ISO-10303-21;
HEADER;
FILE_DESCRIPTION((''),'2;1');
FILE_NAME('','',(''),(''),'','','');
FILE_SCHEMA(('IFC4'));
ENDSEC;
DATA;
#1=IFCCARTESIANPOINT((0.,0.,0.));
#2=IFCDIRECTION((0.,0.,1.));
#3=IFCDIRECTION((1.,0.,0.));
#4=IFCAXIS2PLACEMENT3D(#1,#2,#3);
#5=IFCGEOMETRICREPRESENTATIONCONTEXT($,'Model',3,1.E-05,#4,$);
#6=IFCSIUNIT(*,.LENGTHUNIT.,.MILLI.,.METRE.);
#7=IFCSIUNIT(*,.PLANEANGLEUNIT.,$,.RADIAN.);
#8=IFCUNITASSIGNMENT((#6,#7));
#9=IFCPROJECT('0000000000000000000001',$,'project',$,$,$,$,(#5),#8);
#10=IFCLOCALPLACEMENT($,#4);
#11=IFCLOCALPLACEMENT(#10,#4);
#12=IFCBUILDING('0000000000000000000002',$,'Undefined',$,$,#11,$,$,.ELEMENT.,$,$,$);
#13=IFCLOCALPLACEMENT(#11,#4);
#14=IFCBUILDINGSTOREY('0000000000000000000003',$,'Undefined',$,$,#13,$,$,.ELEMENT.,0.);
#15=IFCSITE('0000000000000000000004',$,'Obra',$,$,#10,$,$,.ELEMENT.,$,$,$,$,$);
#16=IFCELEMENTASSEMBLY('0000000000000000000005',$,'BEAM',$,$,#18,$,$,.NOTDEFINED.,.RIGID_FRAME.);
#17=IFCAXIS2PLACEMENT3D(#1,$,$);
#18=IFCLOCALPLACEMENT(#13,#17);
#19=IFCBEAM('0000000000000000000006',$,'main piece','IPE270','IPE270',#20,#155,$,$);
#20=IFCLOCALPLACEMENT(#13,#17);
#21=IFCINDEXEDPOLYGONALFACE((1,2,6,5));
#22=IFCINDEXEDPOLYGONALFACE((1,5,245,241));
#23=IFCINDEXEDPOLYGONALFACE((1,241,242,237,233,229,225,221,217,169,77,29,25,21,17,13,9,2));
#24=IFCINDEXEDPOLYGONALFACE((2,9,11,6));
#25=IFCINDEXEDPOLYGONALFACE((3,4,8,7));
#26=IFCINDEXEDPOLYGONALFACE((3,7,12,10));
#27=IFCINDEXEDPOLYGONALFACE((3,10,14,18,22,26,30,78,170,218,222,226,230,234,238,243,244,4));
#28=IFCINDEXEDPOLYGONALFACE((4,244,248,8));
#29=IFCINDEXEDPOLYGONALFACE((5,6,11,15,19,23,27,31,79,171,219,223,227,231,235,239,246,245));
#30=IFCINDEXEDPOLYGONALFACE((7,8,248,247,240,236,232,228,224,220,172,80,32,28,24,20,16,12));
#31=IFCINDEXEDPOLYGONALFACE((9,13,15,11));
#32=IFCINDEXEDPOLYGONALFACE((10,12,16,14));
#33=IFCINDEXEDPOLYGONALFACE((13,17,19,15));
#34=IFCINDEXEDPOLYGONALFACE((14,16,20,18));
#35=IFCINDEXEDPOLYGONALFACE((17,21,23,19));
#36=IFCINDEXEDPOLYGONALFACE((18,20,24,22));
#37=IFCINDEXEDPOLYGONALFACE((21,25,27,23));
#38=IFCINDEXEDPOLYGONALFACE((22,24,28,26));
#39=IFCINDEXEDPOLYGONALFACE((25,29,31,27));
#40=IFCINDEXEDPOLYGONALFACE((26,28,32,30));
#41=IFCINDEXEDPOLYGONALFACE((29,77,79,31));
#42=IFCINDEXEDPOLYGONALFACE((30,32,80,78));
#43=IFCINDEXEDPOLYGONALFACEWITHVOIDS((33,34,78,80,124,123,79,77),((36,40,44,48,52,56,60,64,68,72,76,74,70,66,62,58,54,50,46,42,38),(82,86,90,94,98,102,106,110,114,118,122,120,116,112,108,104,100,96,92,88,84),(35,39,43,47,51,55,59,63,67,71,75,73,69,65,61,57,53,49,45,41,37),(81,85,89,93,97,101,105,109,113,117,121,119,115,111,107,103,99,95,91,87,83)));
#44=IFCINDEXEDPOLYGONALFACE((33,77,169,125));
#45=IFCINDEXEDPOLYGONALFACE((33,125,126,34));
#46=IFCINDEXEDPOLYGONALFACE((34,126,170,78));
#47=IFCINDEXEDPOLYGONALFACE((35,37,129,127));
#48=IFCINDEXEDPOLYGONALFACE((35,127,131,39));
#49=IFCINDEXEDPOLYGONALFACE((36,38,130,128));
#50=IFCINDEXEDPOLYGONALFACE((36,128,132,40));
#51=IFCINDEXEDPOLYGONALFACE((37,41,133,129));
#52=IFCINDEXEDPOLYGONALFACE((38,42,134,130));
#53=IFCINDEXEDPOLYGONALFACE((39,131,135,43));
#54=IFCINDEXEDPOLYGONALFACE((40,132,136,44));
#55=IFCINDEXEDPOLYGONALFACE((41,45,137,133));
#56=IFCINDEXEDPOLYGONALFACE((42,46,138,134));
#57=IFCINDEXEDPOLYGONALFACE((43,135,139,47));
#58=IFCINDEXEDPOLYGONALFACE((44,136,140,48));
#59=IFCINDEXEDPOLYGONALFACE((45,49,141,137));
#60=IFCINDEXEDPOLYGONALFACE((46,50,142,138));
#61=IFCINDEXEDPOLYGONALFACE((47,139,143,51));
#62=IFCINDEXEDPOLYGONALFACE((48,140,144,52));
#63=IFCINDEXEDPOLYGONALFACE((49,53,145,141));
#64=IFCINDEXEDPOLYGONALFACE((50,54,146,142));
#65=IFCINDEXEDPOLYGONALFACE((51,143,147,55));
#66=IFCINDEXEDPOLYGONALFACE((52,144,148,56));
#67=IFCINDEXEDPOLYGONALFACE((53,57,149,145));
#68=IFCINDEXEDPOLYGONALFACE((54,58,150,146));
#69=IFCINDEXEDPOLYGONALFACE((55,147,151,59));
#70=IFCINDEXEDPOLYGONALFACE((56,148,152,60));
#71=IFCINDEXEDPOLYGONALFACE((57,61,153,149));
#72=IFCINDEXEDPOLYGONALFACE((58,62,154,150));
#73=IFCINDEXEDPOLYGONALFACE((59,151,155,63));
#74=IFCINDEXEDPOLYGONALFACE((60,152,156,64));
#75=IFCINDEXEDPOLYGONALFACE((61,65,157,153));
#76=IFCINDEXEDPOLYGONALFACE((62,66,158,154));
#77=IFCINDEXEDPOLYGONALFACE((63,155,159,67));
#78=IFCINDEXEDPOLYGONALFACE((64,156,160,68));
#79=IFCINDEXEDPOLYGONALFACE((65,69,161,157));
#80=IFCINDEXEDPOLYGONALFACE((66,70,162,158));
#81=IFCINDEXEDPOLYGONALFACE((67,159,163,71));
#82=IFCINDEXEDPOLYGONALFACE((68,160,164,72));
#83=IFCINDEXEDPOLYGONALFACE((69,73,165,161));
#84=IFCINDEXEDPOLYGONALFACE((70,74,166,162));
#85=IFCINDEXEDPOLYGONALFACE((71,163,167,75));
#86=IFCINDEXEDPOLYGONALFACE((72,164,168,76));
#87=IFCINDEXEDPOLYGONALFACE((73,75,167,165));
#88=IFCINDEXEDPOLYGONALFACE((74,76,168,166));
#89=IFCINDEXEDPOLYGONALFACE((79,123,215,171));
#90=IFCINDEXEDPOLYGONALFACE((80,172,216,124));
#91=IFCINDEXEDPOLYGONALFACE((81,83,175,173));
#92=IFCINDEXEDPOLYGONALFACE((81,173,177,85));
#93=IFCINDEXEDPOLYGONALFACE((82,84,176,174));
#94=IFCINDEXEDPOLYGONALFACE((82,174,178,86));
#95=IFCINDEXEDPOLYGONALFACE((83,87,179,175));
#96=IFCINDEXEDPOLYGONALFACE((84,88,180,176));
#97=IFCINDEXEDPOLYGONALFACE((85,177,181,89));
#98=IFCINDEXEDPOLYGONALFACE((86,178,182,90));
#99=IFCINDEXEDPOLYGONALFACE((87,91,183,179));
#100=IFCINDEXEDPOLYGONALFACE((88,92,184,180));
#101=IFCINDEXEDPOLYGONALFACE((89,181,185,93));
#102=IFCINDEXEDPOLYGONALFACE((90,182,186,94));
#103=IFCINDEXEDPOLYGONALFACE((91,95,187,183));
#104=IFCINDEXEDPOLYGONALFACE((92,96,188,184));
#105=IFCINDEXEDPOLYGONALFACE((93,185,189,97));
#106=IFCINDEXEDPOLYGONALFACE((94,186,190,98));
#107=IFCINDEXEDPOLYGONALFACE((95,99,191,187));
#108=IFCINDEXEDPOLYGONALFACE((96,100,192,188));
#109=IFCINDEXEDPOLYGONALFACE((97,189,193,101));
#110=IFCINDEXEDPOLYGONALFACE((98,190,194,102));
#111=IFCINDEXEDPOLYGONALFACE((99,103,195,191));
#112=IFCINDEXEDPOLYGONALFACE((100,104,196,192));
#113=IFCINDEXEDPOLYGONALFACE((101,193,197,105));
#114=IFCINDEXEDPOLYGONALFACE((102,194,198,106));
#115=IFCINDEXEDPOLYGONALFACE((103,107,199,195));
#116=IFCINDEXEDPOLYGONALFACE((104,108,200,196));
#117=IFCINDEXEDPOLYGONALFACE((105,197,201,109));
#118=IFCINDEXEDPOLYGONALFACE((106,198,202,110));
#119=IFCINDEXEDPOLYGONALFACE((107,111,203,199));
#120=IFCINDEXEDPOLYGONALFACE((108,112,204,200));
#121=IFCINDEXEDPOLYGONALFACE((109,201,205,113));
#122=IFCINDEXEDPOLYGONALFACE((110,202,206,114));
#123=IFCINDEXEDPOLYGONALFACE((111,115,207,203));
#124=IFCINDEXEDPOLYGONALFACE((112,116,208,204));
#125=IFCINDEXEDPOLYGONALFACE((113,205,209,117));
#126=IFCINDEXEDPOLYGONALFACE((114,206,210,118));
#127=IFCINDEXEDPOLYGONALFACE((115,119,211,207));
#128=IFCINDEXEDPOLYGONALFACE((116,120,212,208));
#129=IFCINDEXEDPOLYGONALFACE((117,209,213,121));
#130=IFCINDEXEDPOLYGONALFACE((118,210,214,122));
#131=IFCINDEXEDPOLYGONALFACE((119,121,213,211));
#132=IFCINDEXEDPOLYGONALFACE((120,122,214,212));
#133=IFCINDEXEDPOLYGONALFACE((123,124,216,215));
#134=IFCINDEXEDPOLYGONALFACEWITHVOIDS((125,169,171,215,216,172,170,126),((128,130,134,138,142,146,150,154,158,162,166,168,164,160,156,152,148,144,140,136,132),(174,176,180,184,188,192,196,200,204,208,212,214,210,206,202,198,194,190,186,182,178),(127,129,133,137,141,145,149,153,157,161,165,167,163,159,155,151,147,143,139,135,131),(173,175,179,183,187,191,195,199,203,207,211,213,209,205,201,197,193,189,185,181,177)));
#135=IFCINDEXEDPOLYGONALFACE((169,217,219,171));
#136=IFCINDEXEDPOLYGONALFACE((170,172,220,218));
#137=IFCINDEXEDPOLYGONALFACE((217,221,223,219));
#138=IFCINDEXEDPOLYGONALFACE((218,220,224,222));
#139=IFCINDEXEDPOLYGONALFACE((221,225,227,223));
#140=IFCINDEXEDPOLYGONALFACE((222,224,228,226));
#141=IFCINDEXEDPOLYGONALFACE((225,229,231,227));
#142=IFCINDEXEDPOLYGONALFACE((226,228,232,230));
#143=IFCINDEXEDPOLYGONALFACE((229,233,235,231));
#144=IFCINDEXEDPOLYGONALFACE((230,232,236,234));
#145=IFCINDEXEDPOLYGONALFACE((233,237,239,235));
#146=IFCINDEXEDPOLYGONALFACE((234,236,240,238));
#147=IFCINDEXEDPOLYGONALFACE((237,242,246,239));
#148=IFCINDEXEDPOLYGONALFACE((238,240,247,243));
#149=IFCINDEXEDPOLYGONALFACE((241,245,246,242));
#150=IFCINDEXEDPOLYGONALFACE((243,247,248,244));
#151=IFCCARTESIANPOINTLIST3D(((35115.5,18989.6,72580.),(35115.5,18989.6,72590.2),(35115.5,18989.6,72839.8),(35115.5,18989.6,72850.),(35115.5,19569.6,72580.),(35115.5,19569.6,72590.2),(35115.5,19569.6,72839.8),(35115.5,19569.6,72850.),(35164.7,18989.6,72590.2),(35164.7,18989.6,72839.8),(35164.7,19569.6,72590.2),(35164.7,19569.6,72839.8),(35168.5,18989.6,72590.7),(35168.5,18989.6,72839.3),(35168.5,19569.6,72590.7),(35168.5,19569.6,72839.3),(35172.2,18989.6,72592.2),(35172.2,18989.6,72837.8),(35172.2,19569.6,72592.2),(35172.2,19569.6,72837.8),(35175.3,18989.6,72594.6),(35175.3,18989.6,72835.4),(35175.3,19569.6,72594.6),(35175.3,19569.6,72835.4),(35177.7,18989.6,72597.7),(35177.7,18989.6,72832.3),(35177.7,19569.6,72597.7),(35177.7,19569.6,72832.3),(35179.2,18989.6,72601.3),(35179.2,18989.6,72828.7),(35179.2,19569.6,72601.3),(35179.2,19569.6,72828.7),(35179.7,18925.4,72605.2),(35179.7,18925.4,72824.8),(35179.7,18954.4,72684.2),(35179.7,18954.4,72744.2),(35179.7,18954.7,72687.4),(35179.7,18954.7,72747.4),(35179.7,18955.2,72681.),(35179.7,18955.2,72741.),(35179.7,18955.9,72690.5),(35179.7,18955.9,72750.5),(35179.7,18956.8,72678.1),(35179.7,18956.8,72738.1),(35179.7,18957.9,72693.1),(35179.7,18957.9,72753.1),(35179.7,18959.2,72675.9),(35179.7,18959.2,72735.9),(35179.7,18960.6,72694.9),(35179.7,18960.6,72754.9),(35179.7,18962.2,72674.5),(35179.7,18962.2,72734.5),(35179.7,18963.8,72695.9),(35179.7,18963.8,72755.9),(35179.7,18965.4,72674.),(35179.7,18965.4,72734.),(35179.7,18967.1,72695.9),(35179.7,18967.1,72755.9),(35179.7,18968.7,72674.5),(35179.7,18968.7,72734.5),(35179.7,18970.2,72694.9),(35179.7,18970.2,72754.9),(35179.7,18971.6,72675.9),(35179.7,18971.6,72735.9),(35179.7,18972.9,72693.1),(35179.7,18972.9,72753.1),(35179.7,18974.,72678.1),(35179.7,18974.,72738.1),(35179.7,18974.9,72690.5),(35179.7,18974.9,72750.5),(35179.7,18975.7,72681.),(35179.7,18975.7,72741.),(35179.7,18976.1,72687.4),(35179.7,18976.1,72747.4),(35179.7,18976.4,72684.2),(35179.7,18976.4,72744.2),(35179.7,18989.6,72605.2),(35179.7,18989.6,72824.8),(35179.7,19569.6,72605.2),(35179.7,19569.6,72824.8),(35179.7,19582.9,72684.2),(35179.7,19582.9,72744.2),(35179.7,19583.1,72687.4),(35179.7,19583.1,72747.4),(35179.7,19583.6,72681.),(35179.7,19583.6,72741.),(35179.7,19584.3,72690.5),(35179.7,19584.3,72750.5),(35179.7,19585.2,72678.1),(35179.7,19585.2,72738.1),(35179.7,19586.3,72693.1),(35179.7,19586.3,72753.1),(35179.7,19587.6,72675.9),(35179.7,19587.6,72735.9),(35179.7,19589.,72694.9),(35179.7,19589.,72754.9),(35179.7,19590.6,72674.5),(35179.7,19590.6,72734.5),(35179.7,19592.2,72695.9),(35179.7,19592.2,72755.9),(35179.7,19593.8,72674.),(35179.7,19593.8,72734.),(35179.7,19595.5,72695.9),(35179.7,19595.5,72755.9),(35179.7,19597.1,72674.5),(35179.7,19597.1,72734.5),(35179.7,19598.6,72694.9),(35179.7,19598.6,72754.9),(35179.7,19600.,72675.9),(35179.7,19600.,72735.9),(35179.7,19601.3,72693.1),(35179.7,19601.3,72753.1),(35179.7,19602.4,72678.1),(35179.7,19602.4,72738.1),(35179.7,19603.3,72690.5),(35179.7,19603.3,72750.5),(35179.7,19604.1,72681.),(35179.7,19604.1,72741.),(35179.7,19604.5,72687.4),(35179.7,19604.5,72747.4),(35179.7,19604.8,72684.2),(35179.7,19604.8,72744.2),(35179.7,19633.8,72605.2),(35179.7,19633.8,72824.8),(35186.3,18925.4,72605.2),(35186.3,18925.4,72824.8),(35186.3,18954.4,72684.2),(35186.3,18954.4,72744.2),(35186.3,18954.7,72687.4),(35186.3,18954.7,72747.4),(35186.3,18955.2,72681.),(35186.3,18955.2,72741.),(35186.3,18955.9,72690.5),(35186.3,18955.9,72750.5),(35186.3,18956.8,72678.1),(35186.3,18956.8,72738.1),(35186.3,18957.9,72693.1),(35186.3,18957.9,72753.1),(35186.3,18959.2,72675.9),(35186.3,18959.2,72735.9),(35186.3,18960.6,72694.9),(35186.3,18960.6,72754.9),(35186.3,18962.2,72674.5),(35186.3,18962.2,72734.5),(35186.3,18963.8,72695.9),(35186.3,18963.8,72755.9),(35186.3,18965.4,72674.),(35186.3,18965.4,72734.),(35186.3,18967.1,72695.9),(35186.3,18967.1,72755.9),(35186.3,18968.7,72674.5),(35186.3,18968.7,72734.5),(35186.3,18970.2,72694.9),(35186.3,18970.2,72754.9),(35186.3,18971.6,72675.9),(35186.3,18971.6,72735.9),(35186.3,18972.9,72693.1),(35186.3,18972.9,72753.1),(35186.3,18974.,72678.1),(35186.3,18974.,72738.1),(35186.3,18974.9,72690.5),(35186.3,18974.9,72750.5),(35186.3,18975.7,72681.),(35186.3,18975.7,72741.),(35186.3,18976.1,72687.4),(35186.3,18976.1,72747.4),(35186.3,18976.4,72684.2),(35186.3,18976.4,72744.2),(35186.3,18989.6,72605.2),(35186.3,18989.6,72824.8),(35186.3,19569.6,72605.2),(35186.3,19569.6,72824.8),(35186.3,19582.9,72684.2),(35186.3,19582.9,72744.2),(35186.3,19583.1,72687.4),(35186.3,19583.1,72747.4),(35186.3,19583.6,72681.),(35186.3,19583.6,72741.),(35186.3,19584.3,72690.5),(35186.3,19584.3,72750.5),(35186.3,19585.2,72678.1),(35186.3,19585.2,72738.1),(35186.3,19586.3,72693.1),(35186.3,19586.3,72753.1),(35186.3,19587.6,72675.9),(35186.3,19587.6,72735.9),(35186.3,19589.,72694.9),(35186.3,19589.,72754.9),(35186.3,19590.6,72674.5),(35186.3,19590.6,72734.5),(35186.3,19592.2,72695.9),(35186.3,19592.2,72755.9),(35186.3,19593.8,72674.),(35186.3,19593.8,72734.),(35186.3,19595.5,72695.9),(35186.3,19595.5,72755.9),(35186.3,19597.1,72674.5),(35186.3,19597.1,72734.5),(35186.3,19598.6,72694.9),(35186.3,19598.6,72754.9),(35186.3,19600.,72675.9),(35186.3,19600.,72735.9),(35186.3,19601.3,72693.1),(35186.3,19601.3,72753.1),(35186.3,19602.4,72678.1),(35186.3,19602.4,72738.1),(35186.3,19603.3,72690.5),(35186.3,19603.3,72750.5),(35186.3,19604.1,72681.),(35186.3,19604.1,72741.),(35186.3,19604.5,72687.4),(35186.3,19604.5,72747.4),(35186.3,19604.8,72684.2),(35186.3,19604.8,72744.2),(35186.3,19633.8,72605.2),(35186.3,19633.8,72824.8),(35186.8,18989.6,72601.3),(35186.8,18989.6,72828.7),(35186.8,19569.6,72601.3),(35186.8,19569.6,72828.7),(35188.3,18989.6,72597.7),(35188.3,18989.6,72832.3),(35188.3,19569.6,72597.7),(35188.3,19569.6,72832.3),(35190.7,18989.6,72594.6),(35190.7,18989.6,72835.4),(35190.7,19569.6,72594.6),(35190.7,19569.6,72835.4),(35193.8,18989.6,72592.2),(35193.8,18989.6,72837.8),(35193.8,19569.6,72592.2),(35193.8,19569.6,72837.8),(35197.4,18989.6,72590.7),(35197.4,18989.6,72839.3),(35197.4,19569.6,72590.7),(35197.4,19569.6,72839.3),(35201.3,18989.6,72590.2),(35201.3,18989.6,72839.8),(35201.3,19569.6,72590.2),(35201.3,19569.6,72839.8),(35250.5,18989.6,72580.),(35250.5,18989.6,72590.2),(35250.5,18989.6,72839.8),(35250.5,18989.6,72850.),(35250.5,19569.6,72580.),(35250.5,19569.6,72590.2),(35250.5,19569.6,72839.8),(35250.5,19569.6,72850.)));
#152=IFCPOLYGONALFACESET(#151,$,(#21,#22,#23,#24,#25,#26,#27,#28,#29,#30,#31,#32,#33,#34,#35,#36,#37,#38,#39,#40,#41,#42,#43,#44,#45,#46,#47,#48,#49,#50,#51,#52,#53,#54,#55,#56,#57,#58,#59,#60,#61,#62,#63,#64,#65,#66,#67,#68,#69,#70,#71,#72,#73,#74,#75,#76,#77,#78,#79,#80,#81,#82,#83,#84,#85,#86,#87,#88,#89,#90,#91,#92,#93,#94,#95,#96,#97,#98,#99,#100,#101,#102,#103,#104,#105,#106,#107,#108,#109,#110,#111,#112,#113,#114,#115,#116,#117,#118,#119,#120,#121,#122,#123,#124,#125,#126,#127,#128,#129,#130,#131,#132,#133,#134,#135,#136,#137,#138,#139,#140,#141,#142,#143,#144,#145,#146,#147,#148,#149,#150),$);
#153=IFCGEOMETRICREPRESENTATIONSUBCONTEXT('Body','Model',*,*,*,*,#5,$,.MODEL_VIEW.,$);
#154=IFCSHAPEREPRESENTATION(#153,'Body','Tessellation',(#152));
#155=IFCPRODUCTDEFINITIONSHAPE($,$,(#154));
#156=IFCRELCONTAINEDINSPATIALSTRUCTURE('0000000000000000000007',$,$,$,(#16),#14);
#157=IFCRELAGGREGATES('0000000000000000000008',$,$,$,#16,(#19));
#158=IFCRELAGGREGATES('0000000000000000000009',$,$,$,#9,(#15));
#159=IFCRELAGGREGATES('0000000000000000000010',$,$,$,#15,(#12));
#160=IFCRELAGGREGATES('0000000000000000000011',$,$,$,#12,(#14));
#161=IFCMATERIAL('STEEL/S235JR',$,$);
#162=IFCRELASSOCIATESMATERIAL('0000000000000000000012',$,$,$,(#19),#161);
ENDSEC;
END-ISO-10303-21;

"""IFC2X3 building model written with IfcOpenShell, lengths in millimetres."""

from ifc_helpers import new_model, si_unit, frame, origin_with_axes, origin_2d_with_axis, place, context, subcontext, project, spatial, rectangle, circle, i_section, extrude, clip, halfspace, source, transform, mapped, material, element, aggregate, save


model = new_model("IFC2X3")

# Units and contexts
model_context = context("Model", 3, precision=1e-05, world=origin_with_axes())
body_context = subcontext(model_context, "Body", "Model", "MODEL_VIEW")
ifc_project = project(units=[si_unit("LENGTHUNIT", "METRE", prefix="MILLI"), si_unit("PLANEANGLEUNIT", "RADIAN")], contexts=[model_context])

# Site, building, storey
site_placement = place(None, origin_with_axes())
site = spatial("IfcSite", under=ifc_project, at=site_placement, Name="Obra", CompositionType="ELEMENT")
building_placement = place(site_placement, origin_with_axes())
building = spatial("IfcBuilding", under=site, at=building_placement, Name="Undefined", CompositionType="ELEMENT")
storey_placement = place(building_placement, origin_with_axes())
storey = spatial("IfcBuildingStorey", under=building, at=storey_placement, Name="Undefined", CompositionType="ELEMENT", Elevation=0.0)

# Shared definitions
ifc_material = material(Name="STEEL/S235JR")

# Element assembly, beam, openings
assembly_1_placement = place(storey_placement, origin_with_axes())
assembly_1 = element("IfcElementAssembly", 1, at=assembly_1_placement, inside=storey, Name="BEAM", AssemblyPlace="NOTDEFINED", PredefinedType="RIGID_FRAME")
beam_1_placement = place(assembly_1_placement, frame((35183.0, 18992.4, 72715.0), z_axis=(0.0, 0.0, 1.0), x_axis=(0.0, 1.0, 0.0)))
beam_1 = element("IfcBeam", 2, at=beam_1_placement, material=ifc_material, Name="main piece", Description="IPE270", ObjectType="IPE270", context=body_context, shape_type="Clipping", body=[
    clip(clip(extrude(i_section(OverallWidth=135.0, OverallDepth=270.0, WebThickness=6.6, FlangeThickness=10.2, FilletRadius=15.0, at=origin_2d_with_axis()), frame((641.4, 0.0, 0.0), z_axis=(-1.0, 0.0, 0.0), x_axis=(0.0, -1.0, 0.0)), (0.0, 0.0, 1.0), 708.4), halfspace(frame((641.4, 0.0, -235.0), z_axis=(-1.0, 0.0, 0.0), x_axis=(0.0, 1.0, 0.0)), True)), halfspace(frame((-67.0, 0.0, -235.0), z_axis=(1.0, 0.0, 0.0), x_axis=(0.0, -1.0, 0.0)), True)),
])
opening_1_placement = place(assembly_1_placement, frame((35183.0, 18992.4, 72715.0), z_axis=(0.0, 0.0, 1.0), x_axis=(0.0, 1.0, 0.0)))
element("IfcOpeningElement", 3, at=opening_1_placement, cuts=beam_1, ObjectType="Recess", context=body_context, shape_type="SweptSolid", body=[
    extrude(rectangle(XDim=26.2, YDim=76.2, at=origin_2d_with_axis()), frame((615.3, 68.5, -122.9), z_axis=(0.0, -1.0, 0.0), x_axis=(0.0, 0.0, -1.0)), (0.0, 0.0, 1.0), 137.0),
])
opening_2_placement = place(assembly_1_placement, frame((35183.0, 18992.4, 72715.0), z_axis=(0.0, 0.0, 1.0), x_axis=(0.0, 1.0, 0.0)))
element("IfcOpeningElement", 4, at=opening_2_placement, cuts=beam_1, ObjectType="Recess", context=body_context, shape_type="SweptSolid", body=[
    extrude(rectangle(XDim=26.2, YDim=76.2, at=origin_2d_with_axis()), frame((615.3, 68.5, 122.9), z_axis=(0.0, -1.0, 0.0), x_axis=(0.0, 0.0, -1.0)), (0.0, 0.0, 1.0), 137.0),
])
opening_3_placement = place(assembly_1_placement, frame((35183.0, 18992.4, 72715.0), z_axis=(0.0, 0.0, 1.0), x_axis=(0.0, 1.0, 0.0)))
element("IfcOpeningElement", 5, at=opening_3_placement, cuts=beam_1, ObjectType="Recess", context=body_context, shape_type="SweptSolid", body=[
    extrude(rectangle(XDim=26.2, YDim=76.2, at=origin_2d_with_axis()), frame((-40.9, -68.5, -122.9), z_axis=(0.0, 1.0, 0.0), x_axis=(0.0, 0.0, -1.0)), (0.0, 0.0, 1.0), 137.0),
])
opening_4_placement = place(assembly_1_placement, frame((35183.0, 18992.4, 72715.0), z_axis=(0.0, 0.0, 1.0), x_axis=(0.0, 1.0, 0.0)))
element("IfcOpeningElement", 6, at=opening_4_placement, cuts=beam_1, ObjectType="Recess", context=body_context, shape_type="SweptSolid", body=[
    extrude(rectangle(XDim=26.2, YDim=76.2, at=origin_2d_with_axis()), frame((-40.9, -68.5, 122.9), z_axis=(0.0, 1.0, 0.0), x_axis=(0.0, 0.0, -1.0)), (0.0, 0.0, 1.0), 137.0),
])
shared_shape_1 = source(origin_with_axes(), body_context, "Body", "SweptSolid", [
    extrude(circle(Radius=11.0, at=origin_2d_with_axis()), frame((0.0, -3.4, 0.0), z_axis=(0.0, 1.0, 0.0), x_axis=(1.0, 0.0, 0.0)), (0.0, 0.0, 1.0), 6.8),
])
opening_5_placement = place(assembly_1_placement, frame((35183.0, 19633.8, 72850.0), z_axis=(0.0, -1.0, 0.0), x_axis=(0.0, 0.0, -1.0)))
element("IfcOpeningElement", 7, at=opening_5_placement, cuts=beam_1, ObjectType="Opening", context=body_context, shape_type="MappedRepresentation", body=[
    mapped(shared_shape_1, transform((105.0, 0.0, 40.0))),
    mapped(shared_shape_1, transform((165.0, 0.0, 40.0))),
])
opening_6_placement = place(assembly_1_placement, frame((35183.0, 18925.4, 72850.0), z_axis=(0.0, 1.0, 0.0), x_axis=(0.0, 0.0, -1.0)))
element("IfcOpeningElement", 8, at=opening_6_placement, cuts=beam_1, ObjectType="Opening", context=body_context, shape_type="MappedRepresentation", body=[
    mapped(shared_shape_1, transform((105.0, 0.0, 40.0))),
    mapped(shared_shape_1, transform((165.0, 0.0, 40.0))),
])
aggregate(assembly_1, [beam_1])

save(model, "model.ifc")
